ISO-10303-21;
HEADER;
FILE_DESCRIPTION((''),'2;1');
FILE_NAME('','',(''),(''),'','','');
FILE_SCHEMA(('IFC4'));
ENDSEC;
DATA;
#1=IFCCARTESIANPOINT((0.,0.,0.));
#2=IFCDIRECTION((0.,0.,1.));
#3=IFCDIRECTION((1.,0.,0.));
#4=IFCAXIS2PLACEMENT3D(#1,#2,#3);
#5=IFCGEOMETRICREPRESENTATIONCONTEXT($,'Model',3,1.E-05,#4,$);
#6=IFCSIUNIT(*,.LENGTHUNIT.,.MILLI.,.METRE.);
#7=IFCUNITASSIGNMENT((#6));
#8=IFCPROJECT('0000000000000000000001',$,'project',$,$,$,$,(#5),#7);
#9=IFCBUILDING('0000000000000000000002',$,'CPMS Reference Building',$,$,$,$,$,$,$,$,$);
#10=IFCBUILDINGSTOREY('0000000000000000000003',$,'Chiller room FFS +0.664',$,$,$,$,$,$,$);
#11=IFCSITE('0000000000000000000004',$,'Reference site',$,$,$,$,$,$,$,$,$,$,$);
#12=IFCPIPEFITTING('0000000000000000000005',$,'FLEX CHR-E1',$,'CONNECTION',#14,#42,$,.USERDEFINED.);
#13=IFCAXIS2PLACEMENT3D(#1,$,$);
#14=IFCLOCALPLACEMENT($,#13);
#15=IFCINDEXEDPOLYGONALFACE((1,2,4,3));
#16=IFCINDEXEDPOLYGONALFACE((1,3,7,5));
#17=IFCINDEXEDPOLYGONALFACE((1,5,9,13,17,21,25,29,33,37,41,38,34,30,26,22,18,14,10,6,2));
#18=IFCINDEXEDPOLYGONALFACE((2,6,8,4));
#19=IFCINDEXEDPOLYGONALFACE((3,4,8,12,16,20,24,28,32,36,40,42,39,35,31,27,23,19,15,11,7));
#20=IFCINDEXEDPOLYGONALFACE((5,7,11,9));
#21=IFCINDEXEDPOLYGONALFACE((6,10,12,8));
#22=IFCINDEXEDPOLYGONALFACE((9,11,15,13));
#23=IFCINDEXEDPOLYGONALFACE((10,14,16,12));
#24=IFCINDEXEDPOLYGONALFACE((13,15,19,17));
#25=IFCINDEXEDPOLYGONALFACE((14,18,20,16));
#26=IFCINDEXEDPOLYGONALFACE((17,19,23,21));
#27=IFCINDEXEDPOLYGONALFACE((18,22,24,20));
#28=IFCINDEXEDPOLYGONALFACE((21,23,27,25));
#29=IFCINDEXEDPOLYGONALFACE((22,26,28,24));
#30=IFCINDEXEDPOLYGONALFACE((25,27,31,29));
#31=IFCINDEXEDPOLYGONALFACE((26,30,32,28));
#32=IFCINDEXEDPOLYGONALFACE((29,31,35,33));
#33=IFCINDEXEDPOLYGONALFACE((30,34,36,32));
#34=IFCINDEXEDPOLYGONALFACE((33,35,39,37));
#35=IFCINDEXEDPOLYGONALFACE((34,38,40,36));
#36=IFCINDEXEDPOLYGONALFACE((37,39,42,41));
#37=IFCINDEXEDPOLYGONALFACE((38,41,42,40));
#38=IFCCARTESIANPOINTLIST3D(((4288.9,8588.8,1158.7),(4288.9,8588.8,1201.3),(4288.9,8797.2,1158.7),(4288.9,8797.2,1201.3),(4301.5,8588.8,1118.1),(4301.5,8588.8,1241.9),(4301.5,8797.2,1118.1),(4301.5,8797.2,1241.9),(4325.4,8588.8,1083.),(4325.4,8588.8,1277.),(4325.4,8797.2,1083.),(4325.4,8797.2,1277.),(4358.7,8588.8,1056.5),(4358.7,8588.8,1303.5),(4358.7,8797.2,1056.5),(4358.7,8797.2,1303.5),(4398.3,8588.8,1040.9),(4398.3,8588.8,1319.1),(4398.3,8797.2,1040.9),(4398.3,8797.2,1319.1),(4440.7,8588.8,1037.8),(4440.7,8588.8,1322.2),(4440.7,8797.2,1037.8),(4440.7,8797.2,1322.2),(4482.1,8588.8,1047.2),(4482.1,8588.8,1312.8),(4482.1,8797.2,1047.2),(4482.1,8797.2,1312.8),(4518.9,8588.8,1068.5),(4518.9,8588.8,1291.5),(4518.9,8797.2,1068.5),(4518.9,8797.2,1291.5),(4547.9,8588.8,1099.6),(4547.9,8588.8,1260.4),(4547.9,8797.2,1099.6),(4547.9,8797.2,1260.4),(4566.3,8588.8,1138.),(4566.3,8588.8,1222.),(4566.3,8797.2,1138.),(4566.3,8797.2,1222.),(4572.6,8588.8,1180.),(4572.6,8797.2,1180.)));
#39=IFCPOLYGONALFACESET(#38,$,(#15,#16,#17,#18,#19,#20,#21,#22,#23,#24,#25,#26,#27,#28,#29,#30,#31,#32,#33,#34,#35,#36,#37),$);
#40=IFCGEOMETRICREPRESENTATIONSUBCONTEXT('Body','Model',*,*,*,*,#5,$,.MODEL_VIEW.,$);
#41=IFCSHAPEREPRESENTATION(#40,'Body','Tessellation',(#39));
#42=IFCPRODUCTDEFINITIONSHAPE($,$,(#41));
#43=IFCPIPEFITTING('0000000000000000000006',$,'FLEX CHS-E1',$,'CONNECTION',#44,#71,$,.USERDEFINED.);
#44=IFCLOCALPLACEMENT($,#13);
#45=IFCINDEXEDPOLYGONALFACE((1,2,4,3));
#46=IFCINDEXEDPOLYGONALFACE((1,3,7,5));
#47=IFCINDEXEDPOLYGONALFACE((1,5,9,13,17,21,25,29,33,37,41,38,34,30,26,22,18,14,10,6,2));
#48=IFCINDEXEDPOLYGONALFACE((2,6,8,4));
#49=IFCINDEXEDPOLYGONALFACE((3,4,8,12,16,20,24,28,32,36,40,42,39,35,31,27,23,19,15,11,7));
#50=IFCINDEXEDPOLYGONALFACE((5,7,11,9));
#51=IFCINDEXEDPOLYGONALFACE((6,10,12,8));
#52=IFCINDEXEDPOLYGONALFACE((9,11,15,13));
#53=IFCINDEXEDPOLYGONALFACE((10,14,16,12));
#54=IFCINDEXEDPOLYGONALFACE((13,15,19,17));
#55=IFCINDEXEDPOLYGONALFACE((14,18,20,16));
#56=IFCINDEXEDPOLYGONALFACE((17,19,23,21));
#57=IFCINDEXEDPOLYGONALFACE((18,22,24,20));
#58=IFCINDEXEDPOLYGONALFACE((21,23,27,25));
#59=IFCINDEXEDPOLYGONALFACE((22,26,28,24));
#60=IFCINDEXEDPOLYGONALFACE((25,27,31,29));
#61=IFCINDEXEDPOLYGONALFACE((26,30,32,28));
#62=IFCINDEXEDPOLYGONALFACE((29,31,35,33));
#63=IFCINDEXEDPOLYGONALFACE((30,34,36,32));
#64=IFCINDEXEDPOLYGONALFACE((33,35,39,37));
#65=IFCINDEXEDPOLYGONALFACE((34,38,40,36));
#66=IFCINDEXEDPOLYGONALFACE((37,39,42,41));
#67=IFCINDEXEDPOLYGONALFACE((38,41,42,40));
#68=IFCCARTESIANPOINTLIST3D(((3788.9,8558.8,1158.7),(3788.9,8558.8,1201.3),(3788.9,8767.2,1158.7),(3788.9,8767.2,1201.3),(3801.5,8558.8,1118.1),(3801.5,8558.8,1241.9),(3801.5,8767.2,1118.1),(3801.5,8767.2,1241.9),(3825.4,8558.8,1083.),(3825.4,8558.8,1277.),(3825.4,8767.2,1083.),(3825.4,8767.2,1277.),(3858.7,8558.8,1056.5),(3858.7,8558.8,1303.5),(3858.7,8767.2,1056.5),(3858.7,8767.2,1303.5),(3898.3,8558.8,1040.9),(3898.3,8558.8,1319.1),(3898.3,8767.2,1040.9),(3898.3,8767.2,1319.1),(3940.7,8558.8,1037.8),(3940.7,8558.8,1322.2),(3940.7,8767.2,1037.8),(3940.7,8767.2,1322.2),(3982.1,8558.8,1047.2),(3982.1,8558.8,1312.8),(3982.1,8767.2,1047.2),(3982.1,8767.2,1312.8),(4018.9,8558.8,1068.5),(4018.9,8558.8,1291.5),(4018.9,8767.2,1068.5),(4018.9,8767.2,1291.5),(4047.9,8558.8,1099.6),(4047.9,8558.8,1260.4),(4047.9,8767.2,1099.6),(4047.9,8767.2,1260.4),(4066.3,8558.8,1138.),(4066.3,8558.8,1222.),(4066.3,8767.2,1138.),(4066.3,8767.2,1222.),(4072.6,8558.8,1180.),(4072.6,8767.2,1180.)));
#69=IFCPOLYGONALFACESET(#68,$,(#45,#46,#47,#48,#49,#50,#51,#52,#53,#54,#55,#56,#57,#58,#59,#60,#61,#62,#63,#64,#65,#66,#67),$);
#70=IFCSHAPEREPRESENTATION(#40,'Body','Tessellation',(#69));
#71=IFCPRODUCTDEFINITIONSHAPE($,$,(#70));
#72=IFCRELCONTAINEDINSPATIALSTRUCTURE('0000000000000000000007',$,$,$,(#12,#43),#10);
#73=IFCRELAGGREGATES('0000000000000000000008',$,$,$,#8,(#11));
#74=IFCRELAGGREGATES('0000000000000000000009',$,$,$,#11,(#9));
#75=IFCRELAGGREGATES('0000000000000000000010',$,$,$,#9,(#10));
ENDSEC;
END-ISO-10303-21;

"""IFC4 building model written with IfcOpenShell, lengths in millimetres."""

from ifc_helpers import new_model, si_unit, frame, origin_with_axes, origin_2d, place, context, subcontext, project, spatial, circle_curve, outline, extrude, element, save


model = new_model("IFC4")

# Units and contexts
model_context = context("Model", 3, precision=1e-05, world=origin_with_axes())
body_context = subcontext(model_context, "Body", "Model", "MODEL_VIEW")
ifc_project = project(units=[si_unit("LENGTHUNIT", "METRE", prefix="MILLI")], contexts=[model_context])

# Site, building, storey
site = spatial("IfcSite", under=ifc_project, Name="Reference site")
building = spatial("IfcBuilding", under=site, Name="CPMS Reference Building")
storey = spatial("IfcBuildingStorey", under=building, Name="Chiller room FFS +0.664")

# Pipe fittings
pipe_fitting_1_placement = place(None, origin_with_axes())
element("IfcPipeFitting", 1, at=pipe_fitting_1_placement, inside=storey, Name="FLEX CHR-E1", ObjectType="CONNECTION", PredefinedType="USERDEFINED", context=body_context, shape_type="SweptSolid", body=[
    extrude(outline(circle_curve(origin_2d(), 142.6)), frame((4430.0, 8588.8, 1180.0), z_axis=(0.0, 1.0, 0.0), x_axis=(1.0, 0.0, 0.0)), (0.0, 0.0, 1.0), 208.5),
])
pipe_fitting_2_placement = place(None, origin_with_axes())
element("IfcPipeFitting", 2, at=pipe_fitting_2_placement, inside=storey, Name="FLEX CHS-E1", ObjectType="CONNECTION", PredefinedType="USERDEFINED", context=body_context, shape_type="SweptSolid", body=[
    extrude(outline(circle_curve(origin_2d(), 142.6)), frame((3930.0, 8767.2, 1180.0), z_axis=(0.0, -1.0, 0.0), x_axis=(1.0, 0.0, 0.0)), (0.0, 0.0, 1.0), 208.5),
])

save(model, "model.ifc")
